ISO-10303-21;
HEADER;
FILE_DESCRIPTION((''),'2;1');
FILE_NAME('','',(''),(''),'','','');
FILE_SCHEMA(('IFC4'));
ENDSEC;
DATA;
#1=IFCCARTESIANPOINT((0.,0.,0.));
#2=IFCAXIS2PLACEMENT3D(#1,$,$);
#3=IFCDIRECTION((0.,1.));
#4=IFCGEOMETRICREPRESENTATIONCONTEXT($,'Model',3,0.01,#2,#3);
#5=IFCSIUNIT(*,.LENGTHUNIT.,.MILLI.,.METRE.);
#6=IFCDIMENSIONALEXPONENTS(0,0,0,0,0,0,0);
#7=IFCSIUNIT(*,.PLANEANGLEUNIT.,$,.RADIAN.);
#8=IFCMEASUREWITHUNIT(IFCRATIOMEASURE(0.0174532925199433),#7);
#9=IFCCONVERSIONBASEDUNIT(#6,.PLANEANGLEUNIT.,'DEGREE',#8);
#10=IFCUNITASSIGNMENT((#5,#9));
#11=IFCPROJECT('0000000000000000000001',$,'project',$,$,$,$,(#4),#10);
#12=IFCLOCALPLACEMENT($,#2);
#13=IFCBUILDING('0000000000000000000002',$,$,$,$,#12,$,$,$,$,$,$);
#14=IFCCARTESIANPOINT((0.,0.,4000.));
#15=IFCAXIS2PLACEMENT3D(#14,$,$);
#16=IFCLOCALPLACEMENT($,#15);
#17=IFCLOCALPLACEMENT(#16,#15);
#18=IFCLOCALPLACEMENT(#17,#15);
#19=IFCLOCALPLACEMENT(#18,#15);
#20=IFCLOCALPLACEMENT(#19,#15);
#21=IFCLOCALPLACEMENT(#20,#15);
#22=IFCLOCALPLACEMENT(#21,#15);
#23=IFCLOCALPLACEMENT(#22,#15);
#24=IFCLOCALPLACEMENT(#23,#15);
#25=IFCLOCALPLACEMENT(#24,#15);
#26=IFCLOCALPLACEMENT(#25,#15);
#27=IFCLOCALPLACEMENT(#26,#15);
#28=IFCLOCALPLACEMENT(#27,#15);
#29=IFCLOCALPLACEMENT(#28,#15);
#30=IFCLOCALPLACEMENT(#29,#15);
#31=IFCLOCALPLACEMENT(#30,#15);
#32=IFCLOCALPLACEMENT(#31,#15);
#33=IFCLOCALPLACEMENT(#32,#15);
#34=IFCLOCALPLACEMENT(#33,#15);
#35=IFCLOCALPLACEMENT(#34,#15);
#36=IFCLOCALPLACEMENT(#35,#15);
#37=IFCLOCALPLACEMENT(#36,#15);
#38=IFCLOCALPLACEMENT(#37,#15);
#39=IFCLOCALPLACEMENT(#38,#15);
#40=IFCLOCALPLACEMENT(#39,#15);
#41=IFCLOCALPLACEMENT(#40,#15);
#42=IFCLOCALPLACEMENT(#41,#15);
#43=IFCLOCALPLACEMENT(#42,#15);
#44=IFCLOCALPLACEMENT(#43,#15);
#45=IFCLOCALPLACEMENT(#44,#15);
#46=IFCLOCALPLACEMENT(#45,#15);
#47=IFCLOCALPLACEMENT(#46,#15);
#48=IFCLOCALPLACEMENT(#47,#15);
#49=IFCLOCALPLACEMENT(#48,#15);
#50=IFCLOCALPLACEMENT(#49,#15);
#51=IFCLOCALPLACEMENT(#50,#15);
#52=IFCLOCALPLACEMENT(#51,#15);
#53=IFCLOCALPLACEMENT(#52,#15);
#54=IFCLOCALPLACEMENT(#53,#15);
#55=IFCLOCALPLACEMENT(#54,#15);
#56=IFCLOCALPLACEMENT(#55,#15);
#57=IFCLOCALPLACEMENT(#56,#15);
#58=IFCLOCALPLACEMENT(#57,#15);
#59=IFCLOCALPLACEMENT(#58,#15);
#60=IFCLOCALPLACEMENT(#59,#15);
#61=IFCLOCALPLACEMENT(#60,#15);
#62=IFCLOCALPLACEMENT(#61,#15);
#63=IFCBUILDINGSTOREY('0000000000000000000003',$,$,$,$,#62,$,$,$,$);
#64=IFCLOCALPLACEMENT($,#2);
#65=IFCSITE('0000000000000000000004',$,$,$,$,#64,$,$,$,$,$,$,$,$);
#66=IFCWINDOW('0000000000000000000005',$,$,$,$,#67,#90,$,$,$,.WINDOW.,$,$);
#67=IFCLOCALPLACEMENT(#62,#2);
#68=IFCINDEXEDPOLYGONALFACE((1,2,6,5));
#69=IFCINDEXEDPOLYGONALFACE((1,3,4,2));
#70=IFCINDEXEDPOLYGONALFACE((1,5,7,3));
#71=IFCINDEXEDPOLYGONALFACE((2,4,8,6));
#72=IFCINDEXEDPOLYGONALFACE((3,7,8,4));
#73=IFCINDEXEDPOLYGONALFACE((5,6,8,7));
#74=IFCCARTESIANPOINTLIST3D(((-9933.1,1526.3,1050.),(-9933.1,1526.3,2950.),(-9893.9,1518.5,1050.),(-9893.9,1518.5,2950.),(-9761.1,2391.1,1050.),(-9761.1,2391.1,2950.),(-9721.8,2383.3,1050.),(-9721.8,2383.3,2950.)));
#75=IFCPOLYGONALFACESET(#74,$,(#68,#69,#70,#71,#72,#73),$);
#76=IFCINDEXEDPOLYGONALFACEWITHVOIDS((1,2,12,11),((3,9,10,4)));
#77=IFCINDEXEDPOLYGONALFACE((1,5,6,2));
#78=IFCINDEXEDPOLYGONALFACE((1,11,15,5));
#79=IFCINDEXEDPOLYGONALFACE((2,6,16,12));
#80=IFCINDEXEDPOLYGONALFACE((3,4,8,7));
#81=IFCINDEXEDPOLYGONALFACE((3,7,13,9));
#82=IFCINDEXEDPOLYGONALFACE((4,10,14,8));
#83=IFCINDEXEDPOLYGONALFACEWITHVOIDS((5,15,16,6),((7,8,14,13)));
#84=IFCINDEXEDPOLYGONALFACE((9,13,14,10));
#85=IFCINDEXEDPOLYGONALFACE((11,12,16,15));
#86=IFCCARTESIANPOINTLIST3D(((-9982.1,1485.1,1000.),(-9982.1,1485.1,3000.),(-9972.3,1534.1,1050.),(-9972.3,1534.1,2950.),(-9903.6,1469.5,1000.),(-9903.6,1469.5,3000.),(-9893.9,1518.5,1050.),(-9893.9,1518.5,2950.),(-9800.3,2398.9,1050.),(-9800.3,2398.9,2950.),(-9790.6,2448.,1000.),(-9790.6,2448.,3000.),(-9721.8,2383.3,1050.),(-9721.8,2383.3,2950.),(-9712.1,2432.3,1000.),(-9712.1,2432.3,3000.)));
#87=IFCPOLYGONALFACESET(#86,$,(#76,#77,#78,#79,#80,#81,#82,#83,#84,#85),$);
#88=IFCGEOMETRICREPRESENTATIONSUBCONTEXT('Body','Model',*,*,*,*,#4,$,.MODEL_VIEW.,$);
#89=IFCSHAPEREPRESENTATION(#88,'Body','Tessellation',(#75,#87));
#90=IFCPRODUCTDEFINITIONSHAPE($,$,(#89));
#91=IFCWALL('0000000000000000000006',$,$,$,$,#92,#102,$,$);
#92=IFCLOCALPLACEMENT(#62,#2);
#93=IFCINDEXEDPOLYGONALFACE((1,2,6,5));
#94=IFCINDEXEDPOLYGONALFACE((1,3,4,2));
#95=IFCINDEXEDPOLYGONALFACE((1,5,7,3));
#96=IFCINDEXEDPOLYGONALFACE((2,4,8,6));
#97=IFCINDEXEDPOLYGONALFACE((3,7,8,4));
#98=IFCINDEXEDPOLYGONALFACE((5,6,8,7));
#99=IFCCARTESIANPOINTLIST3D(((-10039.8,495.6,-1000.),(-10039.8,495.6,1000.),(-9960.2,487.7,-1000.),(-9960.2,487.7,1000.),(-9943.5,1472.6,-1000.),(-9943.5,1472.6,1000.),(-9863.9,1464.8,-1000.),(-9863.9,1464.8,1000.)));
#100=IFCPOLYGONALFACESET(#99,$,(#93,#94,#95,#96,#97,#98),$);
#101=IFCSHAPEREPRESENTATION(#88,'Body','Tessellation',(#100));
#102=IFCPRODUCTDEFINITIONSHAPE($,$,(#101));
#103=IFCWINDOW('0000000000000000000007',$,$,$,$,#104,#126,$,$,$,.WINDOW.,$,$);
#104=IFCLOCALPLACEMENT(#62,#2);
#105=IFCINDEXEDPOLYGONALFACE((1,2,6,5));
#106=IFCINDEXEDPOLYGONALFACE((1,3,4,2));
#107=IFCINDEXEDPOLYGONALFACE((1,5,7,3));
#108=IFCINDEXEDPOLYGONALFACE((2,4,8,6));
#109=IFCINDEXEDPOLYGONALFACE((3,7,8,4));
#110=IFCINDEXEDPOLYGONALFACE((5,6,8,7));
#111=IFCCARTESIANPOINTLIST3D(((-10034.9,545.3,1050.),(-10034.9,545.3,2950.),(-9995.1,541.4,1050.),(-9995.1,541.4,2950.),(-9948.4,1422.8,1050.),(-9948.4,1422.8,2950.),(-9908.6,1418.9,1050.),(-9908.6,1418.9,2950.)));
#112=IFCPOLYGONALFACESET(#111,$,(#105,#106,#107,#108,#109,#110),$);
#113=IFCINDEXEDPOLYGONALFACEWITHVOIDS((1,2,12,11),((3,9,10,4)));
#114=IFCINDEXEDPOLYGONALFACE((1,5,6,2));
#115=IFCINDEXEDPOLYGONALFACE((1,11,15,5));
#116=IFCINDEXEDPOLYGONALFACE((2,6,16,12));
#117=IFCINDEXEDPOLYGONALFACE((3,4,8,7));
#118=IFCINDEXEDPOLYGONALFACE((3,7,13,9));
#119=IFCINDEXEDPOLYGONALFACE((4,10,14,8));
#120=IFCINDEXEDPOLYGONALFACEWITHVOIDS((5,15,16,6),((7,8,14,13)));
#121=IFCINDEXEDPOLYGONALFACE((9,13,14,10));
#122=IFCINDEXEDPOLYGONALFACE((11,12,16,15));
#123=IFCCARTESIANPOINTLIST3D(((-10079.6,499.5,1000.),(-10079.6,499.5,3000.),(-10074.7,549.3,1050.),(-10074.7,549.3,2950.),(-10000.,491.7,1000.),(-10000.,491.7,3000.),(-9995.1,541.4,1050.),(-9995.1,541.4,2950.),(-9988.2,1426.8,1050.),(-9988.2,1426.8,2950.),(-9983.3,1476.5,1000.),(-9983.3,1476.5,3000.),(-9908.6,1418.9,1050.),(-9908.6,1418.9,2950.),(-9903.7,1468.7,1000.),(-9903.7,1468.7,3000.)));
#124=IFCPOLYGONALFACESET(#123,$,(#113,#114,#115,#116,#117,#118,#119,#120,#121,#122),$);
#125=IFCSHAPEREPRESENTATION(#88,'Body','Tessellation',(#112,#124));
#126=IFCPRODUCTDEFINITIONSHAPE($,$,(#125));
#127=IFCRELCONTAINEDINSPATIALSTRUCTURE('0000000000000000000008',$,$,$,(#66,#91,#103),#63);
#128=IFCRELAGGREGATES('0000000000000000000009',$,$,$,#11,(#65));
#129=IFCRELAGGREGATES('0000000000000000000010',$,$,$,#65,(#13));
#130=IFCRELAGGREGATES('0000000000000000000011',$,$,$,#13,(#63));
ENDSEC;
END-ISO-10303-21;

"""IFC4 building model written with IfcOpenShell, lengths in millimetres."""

from ifc_helpers import new_model, entity, si_unit, converted_unit, direction, frame, origin, origin_2d, place, context, subcontext, project, spatial, rectangle, extrude, element, save


model = new_model("IFC4")

# Units and contexts
model_context = context("Model", 3, precision=0.01, world=origin(), true_north=direction((0.0, 1.0)))
body_context = subcontext(model_context, "Body", "Model", "MODEL_VIEW")
ifc_project = project(units=[si_unit("LENGTHUNIT", "METRE", prefix="MILLI"), converted_unit("PLANEANGLEUNIT", "DEGREE", entity("IfcRatioMeasure", 0.0174532925199433), si_unit("PLANEANGLEUNIT", "RADIAN"), dimensions=[0, 0, 0, 0, 0, 0, 0])], contexts=[model_context])

# Site, building, storey
site_placement = place(None, origin())
site = spatial("IfcSite", under=ifc_project, at=site_placement)
building_placement = place(None, origin())
building = spatial("IfcBuilding", under=site, at=building_placement)
placement_1 = place(None, frame((0.0, 0.0, 4000.0)))
placement_2 = place(placement_1, frame((0.0, 0.0, 4000.0)))
placement_3 = place(placement_2, frame((0.0, 0.0, 4000.0)))
placement_4 = place(placement_3, frame((0.0, 0.0, 4000.0)))
placement_5 = place(placement_4, frame((0.0, 0.0, 4000.0)))
placement_6 = place(placement_5, frame((0.0, 0.0, 4000.0)))
placement_7 = place(placement_6, frame((0.0, 0.0, 4000.0)))
placement_8 = place(placement_7, frame((0.0, 0.0, 4000.0)))
placement_9 = place(placement_8, frame((0.0, 0.0, 4000.0)))
placement_10 = place(placement_9, frame((0.0, 0.0, 4000.0)))
placement_11 = place(placement_10, frame((0.0, 0.0, 4000.0)))
placement_12 = place(placement_11, frame((0.0, 0.0, 4000.0)))
placement_13 = place(placement_12, frame((0.0, 0.0, 4000.0)))
placement_14 = place(placement_13, frame((0.0, 0.0, 4000.0)))
placement_15 = place(placement_14, frame((0.0, 0.0, 4000.0)))
placement_16 = place(placement_15, frame((0.0, 0.0, 4000.0)))
placement_17 = place(placement_16, frame((0.0, 0.0, 4000.0)))
placement_18 = place(placement_17, frame((0.0, 0.0, 4000.0)))
placement_19 = place(placement_18, frame((0.0, 0.0, 4000.0)))
placement_20 = place(placement_19, frame((0.0, 0.0, 4000.0)))
placement_21 = place(placement_20, frame((0.0, 0.0, 4000.0)))
placement_22 = place(placement_21, frame((0.0, 0.0, 4000.0)))
placement_23 = place(placement_22, frame((0.0, 0.0, 4000.0)))
placement_24 = place(placement_23, frame((0.0, 0.0, 4000.0)))
placement_25 = place(placement_24, frame((0.0, 0.0, 4000.0)))
placement_26 = place(placement_25, frame((0.0, 0.0, 4000.0)))
placement_27 = place(placement_26, frame((0.0, 0.0, 4000.0)))
placement_28 = place(placement_27, frame((0.0, 0.0, 4000.0)))
placement_29 = place(placement_28, frame((0.0, 0.0, 4000.0)))
placement_30 = place(placement_29, frame((0.0, 0.0, 4000.0)))
placement_31 = place(placement_30, frame((0.0, 0.0, 4000.0)))
placement_32 = place(placement_31, frame((0.0, 0.0, 4000.0)))
placement_33 = place(placement_32, frame((0.0, 0.0, 4000.0)))
placement_34 = place(placement_33, frame((0.0, 0.0, 4000.0)))
placement_35 = place(placement_34, frame((0.0, 0.0, 4000.0)))
placement_36 = place(placement_35, frame((0.0, 0.0, 4000.0)))
placement_37 = place(placement_36, frame((0.0, 0.0, 4000.0)))
placement_38 = place(placement_37, frame((0.0, 0.0, 4000.0)))
placement_39 = place(placement_38, frame((0.0, 0.0, 4000.0)))
placement_40 = place(placement_39, frame((0.0, 0.0, 4000.0)))
placement_41 = place(placement_40, frame((0.0, 0.0, 4000.0)))
placement_42 = place(placement_41, frame((0.0, 0.0, 4000.0)))
placement_43 = place(placement_42, frame((0.0, 0.0, 4000.0)))
placement_44 = place(placement_43, frame((0.0, 0.0, 4000.0)))
placement_45 = place(placement_44, frame((0.0, 0.0, 4000.0)))
placement_46 = place(placement_45, frame((0.0, 0.0, 4000.0)))
storey_placement = place(placement_46, frame((0.0, 0.0, 4000.0)))
storey = spatial("IfcBuildingStorey", under=building, at=storey_placement)

# Shared definitions
cartesian_point_1 = entity("IfcCartesianPoint", [-440.9, -950.0])
shared_polyline = entity("IfcPolyline", [cartesian_point_1, entity("IfcCartesianPoint", [-440.9, 950.0]), entity("IfcCartesianPoint", [-440.9, 950.0]), entity("IfcCartesianPoint", [440.9, 950.0]), entity("IfcCartesianPoint", [440.9, 950.0]), entity("IfcCartesianPoint", [440.9, -950.0]), entity("IfcCartesianPoint", [440.9, -950.0]), entity("IfcCartesianPoint", [-440.9, -950.0]), cartesian_point_1])

# Window
window_1_placement = place(storey_placement, frame((-9807.9, 1950.9, 2000.0), z_axis=(0.0, 0.0, 1.0), x_axis=(-1950.903147, -9807.852819, 0.0)))
cartesian_point_2 = entity("IfcCartesianPoint", [-490.9, -1000.0])
element("IfcWindow", 1, at=window_1_placement, inside=storey, PredefinedType="WINDOW", context=body_context, shape_type="SweptSolid", body=[
    entity("IfcExtrudedAreaSolid", entity("IfcArbitraryClosedProfileDef", "AREA", None, shared_polyline), entity("IfcAxis2Placement3D", entity("IfcCartesianPoint", [0.0, 0.0, 0.0]), entity("IfcDirection", [0.0, -1.0, 0.0]), entity("IfcDirection", [1.0, 0.0, 0.0])), entity("IfcDirection", [0.0, 0.0, 1.0]), 40.0),
    entity("IfcExtrudedAreaSolid", entity("IfcArbitraryProfileDefWithVoids", "AREA", None, entity("IfcPolyline", [cartesian_point_2, entity("IfcCartesianPoint", [-490.9, 1000.0]), entity("IfcCartesianPoint", [-490.9, 1000.0]), entity("IfcCartesianPoint", [490.9, 1000.0]), entity("IfcCartesianPoint", [490.9, 1000.0]), entity("IfcCartesianPoint", [490.9, -1000.0]), entity("IfcCartesianPoint", [490.9, -1000.0]), entity("IfcCartesianPoint", [-490.9, -1000.0]), cartesian_point_2]), [shared_polyline]), entity("IfcAxis2Placement3D", entity("IfcCartesianPoint", [0.0, 0.0, 0.0]), entity("IfcDirection", [0.0, -1.0, 0.0]), entity("IfcDirection", [1.0, 0.0, 0.0])), entity("IfcDirection", [0.0, 0.0, 1.0]), 80.0),
])

# Wall
wall_1_placement = place(storey_placement, frame((-9951.8, 980.2, -1000.0), z_axis=(0.0, 0.0, 1.0), x_axis=(-980.170931, -9951.847313, 0.0)))
element("IfcWall", 2, at=wall_1_placement, inside=storey, context=body_context, shape_type="SweptSolid", body=[
    extrude(rectangle(XDim=981.7, YDim=80.0, at=origin_2d()), origin(), (0.0, 0.0, 1.0), 2000.0),
])

# Window
window_2_placement = place(storey_placement, frame((-9951.8, 980.2, 2000.0), z_axis=(0.0, 0.0, 1.0), x_axis=(-980.170931, -9951.847313, 0.0)))
cartesian_point_3 = entity("IfcCartesianPoint", [-490.9, -1000.0])
element("IfcWindow", 3, at=window_2_placement, inside=storey, PredefinedType="WINDOW", context=body_context, shape_type="SweptSolid", body=[
    entity("IfcExtrudedAreaSolid", entity("IfcArbitraryClosedProfileDef", "AREA", None, shared_polyline), entity("IfcAxis2Placement3D", entity("IfcCartesianPoint", [0.0, 0.0, 0.0]), entity("IfcDirection", [0.0, -1.0, 0.0]), entity("IfcDirection", [1.0, 0.0, 0.0])), entity("IfcDirection", [0.0, 0.0, 1.0]), 40.0),
    entity("IfcExtrudedAreaSolid", entity("IfcArbitraryProfileDefWithVoids", "AREA", None, entity("IfcPolyline", [cartesian_point_3, entity("IfcCartesianPoint", [-490.9, 1000.0]), entity("IfcCartesianPoint", [-490.9, 1000.0]), entity("IfcCartesianPoint", [490.9, 1000.0]), entity("IfcCartesianPoint", [490.9, 1000.0]), entity("IfcCartesianPoint", [490.9, -1000.0]), entity("IfcCartesianPoint", [490.9, -1000.0]), entity("IfcCartesianPoint", [-490.9, -1000.0]), cartesian_point_3]), [shared_polyline]), entity("IfcAxis2Placement3D", entity("IfcCartesianPoint", [0.0, 0.0, 0.0]), entity("IfcDirection", [0.0, -1.0, 0.0]), entity("IfcDirection", [1.0, 0.0, 0.0])), entity("IfcDirection", [0.0, 0.0, 1.0]), 80.0),
])

save(model, "model.ifc")
